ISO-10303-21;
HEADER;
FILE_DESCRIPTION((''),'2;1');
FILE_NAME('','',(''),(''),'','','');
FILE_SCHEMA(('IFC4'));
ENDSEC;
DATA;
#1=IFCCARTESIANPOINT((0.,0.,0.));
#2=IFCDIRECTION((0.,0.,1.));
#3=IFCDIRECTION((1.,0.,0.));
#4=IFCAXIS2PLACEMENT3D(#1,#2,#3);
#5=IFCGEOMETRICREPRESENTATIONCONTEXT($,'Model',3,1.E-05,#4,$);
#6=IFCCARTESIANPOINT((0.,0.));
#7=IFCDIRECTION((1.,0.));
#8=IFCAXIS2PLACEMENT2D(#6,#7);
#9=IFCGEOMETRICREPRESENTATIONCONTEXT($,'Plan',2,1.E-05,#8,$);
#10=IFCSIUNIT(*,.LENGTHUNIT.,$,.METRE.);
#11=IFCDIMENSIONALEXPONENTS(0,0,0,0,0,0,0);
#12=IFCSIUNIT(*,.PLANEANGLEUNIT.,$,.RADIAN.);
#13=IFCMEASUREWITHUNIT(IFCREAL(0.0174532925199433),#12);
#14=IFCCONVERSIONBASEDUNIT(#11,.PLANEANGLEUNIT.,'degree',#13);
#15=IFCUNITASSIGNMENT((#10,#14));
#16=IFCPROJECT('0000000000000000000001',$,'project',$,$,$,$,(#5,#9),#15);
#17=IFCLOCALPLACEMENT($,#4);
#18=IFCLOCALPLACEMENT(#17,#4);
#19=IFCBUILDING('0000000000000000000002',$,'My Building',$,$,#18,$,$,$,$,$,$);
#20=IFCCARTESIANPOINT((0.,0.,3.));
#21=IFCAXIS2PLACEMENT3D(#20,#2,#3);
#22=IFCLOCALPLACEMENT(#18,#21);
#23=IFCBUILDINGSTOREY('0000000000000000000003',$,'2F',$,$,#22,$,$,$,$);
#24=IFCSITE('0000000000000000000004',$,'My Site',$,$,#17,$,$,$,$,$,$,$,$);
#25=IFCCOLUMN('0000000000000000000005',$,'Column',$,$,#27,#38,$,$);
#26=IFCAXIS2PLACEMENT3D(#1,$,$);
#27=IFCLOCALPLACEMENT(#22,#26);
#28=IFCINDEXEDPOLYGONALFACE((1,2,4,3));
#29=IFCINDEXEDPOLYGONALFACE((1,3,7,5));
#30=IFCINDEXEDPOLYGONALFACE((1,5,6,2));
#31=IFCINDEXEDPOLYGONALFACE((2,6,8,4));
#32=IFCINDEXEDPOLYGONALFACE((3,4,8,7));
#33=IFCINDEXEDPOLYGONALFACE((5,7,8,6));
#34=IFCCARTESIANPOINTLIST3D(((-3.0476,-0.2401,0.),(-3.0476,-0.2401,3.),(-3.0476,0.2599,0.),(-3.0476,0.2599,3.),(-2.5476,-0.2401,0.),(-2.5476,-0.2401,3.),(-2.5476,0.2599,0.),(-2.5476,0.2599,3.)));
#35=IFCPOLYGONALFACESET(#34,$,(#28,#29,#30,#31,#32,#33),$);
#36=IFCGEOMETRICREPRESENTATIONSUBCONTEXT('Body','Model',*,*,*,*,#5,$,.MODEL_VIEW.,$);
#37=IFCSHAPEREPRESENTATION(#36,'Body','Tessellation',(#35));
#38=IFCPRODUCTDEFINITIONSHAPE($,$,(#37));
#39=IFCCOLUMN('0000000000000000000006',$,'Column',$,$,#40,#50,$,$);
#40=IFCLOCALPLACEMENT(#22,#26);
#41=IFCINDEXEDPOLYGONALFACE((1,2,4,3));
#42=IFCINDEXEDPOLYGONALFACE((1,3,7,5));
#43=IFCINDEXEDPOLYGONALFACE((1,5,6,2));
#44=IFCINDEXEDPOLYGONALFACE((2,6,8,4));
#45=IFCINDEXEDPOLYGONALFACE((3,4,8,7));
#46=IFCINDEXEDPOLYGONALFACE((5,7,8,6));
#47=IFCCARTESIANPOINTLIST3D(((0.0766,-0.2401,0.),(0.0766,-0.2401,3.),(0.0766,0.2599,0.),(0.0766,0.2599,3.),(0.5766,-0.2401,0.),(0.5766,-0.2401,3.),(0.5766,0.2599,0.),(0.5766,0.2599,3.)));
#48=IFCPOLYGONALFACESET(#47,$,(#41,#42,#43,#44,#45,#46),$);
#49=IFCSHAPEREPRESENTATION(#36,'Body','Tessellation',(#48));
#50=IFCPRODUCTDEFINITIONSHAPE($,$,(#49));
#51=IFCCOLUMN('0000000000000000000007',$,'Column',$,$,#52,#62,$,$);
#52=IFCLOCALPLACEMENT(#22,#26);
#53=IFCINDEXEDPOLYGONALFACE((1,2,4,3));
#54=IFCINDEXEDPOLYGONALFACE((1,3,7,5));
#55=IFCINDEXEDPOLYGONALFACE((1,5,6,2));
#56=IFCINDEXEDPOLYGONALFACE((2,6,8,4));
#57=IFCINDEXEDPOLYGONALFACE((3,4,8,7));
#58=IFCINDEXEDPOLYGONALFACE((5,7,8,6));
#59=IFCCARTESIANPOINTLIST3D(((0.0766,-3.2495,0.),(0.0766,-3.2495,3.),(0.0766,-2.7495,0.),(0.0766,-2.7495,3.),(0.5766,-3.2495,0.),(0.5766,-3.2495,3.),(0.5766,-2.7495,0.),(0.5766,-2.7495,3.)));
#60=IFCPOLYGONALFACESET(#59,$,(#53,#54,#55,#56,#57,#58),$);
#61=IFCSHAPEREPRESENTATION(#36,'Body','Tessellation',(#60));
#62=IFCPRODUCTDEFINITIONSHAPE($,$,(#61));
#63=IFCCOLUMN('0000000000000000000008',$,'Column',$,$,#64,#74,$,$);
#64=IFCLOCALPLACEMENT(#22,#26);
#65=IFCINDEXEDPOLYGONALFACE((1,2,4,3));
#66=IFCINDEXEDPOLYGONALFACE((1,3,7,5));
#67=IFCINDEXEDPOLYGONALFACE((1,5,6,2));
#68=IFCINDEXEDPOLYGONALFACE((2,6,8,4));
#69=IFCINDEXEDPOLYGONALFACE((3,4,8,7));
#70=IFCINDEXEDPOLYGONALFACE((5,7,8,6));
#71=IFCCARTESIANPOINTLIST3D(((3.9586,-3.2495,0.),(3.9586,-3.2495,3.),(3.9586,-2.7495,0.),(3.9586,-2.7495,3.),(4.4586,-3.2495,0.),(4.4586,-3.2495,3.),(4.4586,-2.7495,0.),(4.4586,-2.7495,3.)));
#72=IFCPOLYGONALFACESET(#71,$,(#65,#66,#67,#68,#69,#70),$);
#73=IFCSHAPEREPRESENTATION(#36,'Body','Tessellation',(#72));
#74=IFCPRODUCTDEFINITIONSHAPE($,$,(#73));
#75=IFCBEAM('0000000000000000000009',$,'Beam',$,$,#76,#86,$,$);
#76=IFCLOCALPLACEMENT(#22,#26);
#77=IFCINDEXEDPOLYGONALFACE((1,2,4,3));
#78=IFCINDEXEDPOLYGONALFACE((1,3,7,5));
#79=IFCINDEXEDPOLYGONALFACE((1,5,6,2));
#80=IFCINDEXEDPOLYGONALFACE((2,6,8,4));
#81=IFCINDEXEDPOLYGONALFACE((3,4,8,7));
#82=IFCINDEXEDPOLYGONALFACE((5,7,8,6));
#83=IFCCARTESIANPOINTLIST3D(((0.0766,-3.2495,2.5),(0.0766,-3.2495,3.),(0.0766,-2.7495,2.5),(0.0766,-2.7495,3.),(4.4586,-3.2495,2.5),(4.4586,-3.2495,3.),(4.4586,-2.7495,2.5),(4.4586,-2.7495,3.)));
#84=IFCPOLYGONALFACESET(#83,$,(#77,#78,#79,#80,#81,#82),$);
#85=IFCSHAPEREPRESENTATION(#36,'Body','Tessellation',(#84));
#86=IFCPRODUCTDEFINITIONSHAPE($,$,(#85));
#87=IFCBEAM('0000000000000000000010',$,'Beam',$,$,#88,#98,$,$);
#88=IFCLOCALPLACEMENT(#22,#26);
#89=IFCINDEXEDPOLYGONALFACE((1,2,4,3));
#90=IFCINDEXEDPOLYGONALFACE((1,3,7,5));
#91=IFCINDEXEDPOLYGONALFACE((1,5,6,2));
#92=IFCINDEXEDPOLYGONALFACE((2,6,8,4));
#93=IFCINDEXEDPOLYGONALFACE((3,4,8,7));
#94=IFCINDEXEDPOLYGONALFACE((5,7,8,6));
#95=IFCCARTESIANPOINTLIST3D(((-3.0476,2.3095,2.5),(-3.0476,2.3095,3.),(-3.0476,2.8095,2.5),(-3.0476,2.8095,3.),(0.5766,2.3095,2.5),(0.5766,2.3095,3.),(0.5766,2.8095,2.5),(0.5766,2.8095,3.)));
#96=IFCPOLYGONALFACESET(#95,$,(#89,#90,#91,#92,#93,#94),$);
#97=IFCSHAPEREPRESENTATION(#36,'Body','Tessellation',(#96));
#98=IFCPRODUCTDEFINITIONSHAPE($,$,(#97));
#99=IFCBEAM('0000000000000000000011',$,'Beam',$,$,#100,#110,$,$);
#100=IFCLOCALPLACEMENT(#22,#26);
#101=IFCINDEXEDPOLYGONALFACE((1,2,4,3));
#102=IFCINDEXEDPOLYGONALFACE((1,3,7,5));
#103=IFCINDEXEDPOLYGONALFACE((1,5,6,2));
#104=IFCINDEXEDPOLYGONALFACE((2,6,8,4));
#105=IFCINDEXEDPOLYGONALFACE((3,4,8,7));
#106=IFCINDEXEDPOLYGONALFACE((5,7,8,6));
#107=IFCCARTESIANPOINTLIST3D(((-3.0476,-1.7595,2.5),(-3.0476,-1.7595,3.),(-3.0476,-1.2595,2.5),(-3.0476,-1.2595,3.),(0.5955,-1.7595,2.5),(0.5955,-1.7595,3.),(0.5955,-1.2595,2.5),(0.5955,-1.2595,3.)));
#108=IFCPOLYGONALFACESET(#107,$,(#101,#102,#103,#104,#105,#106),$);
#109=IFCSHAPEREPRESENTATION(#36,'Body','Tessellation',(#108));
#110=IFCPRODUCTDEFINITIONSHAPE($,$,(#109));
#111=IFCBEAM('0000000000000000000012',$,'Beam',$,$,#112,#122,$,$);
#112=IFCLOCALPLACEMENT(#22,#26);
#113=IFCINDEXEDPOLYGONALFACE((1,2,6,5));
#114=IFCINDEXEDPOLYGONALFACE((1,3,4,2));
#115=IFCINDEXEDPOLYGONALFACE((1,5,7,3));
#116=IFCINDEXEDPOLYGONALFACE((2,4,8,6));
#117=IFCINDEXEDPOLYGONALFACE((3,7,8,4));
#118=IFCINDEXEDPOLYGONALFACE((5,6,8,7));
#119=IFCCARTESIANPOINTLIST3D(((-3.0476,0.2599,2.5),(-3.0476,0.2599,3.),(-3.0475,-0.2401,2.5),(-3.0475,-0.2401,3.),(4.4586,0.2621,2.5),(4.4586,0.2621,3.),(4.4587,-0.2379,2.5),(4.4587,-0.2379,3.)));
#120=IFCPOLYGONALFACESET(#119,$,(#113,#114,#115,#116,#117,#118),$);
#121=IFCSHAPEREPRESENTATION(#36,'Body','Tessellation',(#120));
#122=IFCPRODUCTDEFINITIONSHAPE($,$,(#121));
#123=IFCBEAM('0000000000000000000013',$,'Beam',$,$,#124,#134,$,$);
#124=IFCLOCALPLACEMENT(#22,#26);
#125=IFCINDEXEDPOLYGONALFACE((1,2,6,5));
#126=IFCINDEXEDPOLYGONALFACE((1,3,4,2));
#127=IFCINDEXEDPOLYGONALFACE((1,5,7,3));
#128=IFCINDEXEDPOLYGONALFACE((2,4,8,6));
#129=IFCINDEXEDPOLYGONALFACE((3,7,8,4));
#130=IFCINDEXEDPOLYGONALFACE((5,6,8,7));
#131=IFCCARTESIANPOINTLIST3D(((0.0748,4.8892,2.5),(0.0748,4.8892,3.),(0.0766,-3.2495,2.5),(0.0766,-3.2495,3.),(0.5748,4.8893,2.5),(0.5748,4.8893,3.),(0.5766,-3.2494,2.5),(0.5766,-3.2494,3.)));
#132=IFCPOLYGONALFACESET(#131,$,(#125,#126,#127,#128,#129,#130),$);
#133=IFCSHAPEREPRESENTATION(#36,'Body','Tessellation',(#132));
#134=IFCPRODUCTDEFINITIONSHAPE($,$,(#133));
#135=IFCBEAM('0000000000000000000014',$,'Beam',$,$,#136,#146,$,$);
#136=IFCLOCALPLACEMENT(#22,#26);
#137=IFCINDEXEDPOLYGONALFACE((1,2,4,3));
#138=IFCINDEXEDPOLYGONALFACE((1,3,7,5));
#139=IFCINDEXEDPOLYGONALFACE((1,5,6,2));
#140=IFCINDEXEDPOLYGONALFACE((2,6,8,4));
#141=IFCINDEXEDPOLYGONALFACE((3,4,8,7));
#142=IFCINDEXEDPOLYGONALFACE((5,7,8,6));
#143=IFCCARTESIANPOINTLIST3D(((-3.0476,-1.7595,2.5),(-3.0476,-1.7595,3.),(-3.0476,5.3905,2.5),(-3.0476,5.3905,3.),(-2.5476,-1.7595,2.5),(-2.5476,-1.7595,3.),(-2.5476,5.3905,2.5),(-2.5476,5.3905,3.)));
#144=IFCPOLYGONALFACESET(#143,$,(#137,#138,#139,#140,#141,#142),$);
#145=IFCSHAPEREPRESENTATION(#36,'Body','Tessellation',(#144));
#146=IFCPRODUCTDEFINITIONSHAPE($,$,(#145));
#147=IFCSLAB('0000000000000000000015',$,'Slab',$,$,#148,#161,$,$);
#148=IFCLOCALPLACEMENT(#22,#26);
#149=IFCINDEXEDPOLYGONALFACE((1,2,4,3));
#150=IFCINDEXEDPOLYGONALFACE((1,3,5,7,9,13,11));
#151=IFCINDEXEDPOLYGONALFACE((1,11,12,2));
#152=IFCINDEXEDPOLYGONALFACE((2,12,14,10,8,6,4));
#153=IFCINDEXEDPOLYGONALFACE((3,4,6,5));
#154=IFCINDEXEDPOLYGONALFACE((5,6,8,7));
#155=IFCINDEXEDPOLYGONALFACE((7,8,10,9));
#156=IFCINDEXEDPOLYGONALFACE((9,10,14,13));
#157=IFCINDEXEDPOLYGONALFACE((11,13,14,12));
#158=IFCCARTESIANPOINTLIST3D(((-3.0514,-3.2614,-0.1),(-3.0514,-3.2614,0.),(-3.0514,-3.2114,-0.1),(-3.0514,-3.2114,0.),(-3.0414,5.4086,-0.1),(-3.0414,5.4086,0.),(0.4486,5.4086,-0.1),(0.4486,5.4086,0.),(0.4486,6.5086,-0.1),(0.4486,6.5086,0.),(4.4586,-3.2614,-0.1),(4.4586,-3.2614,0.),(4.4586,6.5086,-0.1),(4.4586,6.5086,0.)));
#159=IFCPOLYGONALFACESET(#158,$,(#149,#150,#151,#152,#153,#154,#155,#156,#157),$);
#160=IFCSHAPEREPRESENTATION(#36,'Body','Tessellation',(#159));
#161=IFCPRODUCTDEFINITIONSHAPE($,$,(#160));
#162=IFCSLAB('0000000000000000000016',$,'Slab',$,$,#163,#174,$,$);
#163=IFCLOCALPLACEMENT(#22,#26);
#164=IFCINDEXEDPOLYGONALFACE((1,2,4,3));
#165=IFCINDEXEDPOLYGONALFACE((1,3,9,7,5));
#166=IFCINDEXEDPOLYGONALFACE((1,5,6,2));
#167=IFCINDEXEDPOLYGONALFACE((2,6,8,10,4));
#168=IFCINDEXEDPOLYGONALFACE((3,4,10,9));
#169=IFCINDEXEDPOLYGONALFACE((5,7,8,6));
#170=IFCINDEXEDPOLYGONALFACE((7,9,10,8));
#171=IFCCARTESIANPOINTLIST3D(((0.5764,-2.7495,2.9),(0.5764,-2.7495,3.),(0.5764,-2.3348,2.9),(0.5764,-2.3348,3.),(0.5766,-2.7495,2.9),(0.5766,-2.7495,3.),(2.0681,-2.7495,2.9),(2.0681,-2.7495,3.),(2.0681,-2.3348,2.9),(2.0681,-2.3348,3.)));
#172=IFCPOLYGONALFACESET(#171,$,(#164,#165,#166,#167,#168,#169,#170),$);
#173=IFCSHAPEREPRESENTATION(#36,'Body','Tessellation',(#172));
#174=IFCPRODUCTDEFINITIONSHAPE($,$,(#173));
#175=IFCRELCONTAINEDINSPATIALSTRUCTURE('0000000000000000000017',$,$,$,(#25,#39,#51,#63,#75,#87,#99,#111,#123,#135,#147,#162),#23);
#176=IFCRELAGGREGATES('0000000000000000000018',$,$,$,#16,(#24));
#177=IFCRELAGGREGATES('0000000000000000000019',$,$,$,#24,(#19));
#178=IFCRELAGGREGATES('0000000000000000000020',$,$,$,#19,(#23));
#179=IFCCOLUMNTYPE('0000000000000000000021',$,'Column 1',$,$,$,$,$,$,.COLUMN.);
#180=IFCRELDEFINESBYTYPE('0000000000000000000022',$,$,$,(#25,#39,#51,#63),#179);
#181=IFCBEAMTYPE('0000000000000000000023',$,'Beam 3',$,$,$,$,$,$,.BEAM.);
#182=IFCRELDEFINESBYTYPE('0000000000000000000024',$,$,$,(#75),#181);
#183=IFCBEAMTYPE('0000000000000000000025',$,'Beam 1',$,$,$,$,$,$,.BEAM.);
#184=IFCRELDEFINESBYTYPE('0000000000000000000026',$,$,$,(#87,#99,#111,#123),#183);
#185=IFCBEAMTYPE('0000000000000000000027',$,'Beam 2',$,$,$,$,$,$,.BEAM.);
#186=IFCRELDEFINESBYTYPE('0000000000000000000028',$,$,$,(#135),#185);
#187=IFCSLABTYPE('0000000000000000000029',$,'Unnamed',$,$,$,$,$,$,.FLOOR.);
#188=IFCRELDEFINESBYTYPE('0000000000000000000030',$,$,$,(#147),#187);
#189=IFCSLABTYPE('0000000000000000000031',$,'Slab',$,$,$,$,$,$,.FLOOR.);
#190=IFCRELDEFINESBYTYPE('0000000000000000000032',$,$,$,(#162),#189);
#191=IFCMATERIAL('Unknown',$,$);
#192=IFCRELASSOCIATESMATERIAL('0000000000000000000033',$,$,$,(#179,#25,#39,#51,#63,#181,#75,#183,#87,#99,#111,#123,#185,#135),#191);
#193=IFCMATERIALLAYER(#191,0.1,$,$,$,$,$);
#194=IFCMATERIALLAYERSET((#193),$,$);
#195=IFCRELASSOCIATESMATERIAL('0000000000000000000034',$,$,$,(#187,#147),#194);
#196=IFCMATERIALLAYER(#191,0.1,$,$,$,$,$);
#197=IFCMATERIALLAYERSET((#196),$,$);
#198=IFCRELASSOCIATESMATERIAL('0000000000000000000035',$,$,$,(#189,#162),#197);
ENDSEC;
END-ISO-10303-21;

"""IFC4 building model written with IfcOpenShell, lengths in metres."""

from ifc_helpers import new_model, entity, si_unit, converted_unit, frame, origin_with_axes, origin_2d_with_axis, place, context, subcontext, project, spatial, indexed_curve, outline, extrude, material, layer, layer_set, layer_usage, material_profile, profile_set, profile_usage, type_object, element, save


model = new_model("IFC4")

# Units and contexts
model_context = context("Model", 3, precision=1e-05, world=origin_with_axes())
plan_context = context("Plan", 2, precision=1e-05, world=origin_2d_with_axis())
body_context_1 = subcontext(model_context, "Body", "Model", "MODEL_VIEW")
ifc_project = project(units=[si_unit("LENGTHUNIT", "METRE"), converted_unit("PLANEANGLEUNIT", "degree", entity("IfcReal", 0.0174532925199433), si_unit("PLANEANGLEUNIT", "RADIAN"), dimensions=[0, 0, 0, 0, 0, 0, 0])], contexts=[model_context, plan_context])

# Site, building, storey
site_placement = place(None, origin_with_axes())
site = spatial("IfcSite", under=ifc_project, at=site_placement, Name="My Site")
building_placement = place(site_placement, origin_with_axes())
building = spatial("IfcBuilding", under=site, at=building_placement, Name="My Building")
storey_placement = place(building_placement, frame((0.0, 0.0, 3.0), z_axis=(0.0, 0.0, 1.0), x_axis=(1.0, 0.0, 0.0)))
storey = spatial("IfcBuildingStorey", under=building, at=storey_placement, Name="2F")

# Columns
ifc_material = material(Name="Unknown")
ifc_material_profile_1 = material_profile(ifc_material, outline(indexed_curve([(-0.25, -0.25), (0.25, -0.25), (0.25, 0.25), (-0.25, 0.25), (-0.25, -0.25)])))
ifc_profile_set_1 = profile_set([ifc_material_profile_1])
ifc_profile_usage_1 = profile_usage(ifc_profile_set_1, cardinal=7)
column_type = type_object("IfcColumnType", Name="Column 1", PredefinedType="COLUMN", material=ifc_profile_set_1)
column_1_placement = place(storey_placement, frame((-2.5476, 0.2599, 0.0), z_axis=(0.0, 0.0, 1.0), x_axis=(1.0, 0.0, 0.0)))
element("IfcColumn", 1, at=column_1_placement, inside=storey, type_object=column_type, material=ifc_profile_usage_1, Name="Column", context=body_context_1, shape_type="SweptSolid", body=[
    extrude(outline(indexed_curve([(-0.25, -0.25), (0.25, -0.25), (0.25, 0.25), (-0.25, 0.25), (-0.25, -0.25)])), frame((-0.25, -0.25, 0.0), z_axis=(0.0, 0.0, 1.0), x_axis=(1.0, 0.0, 0.0)), (0.0, 0.0, 1.0), 3.0),
])
ifc_profile_usage_2 = profile_usage(ifc_profile_set_1, cardinal=9)
column_2_placement = place(storey_placement, frame((0.0766, 0.2599, 0.0), z_axis=(0.0, 0.0, 1.0), x_axis=(1.0, 0.0, 0.0)))
element("IfcColumn", 2, at=column_2_placement, inside=storey, type_object=column_type, material=ifc_profile_usage_2, Name="Column", context=body_context_1, shape_type="SweptSolid", body=[
    extrude(outline(indexed_curve([(-0.25, -0.25), (0.25, -0.25), (0.25, 0.25), (-0.25, 0.25), (-0.25, -0.25)])), frame((0.25, -0.25, 0.0), z_axis=(0.0, 0.0, 1.0), x_axis=(1.0, 0.0, 0.0)), (0.0, 0.0, 1.0), 3.0),
])
ifc_profile_usage_3 = profile_usage(ifc_profile_set_1, cardinal=3)
column_3_placement = place(storey_placement, frame((0.0766, -3.2495, 0.0), z_axis=(0.0, 0.0, 1.0), x_axis=(1.0, 0.0, 0.0)))
element("IfcColumn", 3, at=column_3_placement, inside=storey, type_object=column_type, material=ifc_profile_usage_3, Name="Column", context=body_context_1, shape_type="SweptSolid", body=[
    extrude(outline(indexed_curve([(-0.25, -0.25), (0.25, -0.25), (0.25, 0.25), (-0.25, 0.25), (-0.25, -0.25)])), frame((0.25, 0.25, 0.0), z_axis=(0.0, 0.0, 1.0), x_axis=(1.0, 0.0, 0.0)), (0.0, 0.0, 1.0), 3.0),
])
ifc_profile_usage_4 = profile_usage(ifc_profile_set_1, cardinal=3)
column_4_placement = place(storey_placement, frame((3.9586, -3.2495, 0.0), z_axis=(0.0, 0.0, 1.0), x_axis=(1.0, 0.0, 0.0)))
element("IfcColumn", 4, at=column_4_placement, inside=storey, type_object=column_type, material=ifc_profile_usage_4, Name="Column", context=body_context_1, shape_type="SweptSolid", body=[
    extrude(outline(indexed_curve([(-0.25, -0.25), (0.25, -0.25), (0.25, 0.25), (-0.25, 0.25), (-0.25, -0.25)])), frame((0.25, 0.25, 0.0), z_axis=(0.0, 0.0, 1.0), x_axis=(1.0, 0.0, 0.0)), (0.0, 0.0, 1.0), 3.0),
])

# Beams
ifc_material_profile_2 = material_profile(ifc_material, outline(indexed_curve([(-0.25, -0.25), (0.25, -0.25), (0.25, 0.25), (-0.25, 0.25), (-0.25, -0.25)])))
ifc_profile_set_2 = profile_set([ifc_material_profile_2])
ifc_profile_usage_5 = profile_usage(ifc_profile_set_2, cardinal=7)
beam_type_1 = type_object("IfcBeamType", Name="Beam 3", PredefinedType="BEAM", material=ifc_profile_set_2)
beam_1_placement = place(storey_placement, frame((0.0766, -2.7495, 3.0), z_axis=(1.0, 0.0, 0.0), x_axis=(0.0, 1.0, 0.0)))
element("IfcBeam", 5, at=beam_1_placement, inside=storey, type_object=beam_type_1, material=ifc_profile_usage_5, Name="Beam", context=body_context_1, shape_type="SweptSolid", body=[
    extrude(outline(indexed_curve([(-0.25, -0.25), (0.25, -0.25), (0.25, 0.25), (-0.25, 0.25), (-0.25, -0.25)])), frame((-0.25, -0.25, 0.0), z_axis=(0.0, 0.0, 1.0), x_axis=(1.0, 0.0, 0.0)), (0.0, 0.0, 1.0), 4.382),
])
ifc_material_profile_3 = material_profile(ifc_material, outline(indexed_curve([(-0.25, -0.25), (0.25, -0.25), (0.25, 0.25), (-0.25, 0.25), (-0.25, -0.25)])))
ifc_profile_set_3 = profile_set([ifc_material_profile_3])
ifc_profile_usage_6 = profile_usage(ifc_profile_set_3, cardinal=7)
beam_type_2 = type_object("IfcBeamType", Name="Beam 1", PredefinedType="BEAM", material=ifc_profile_set_3)
beam_2_placement = place(storey_placement, frame((0.5766, 2.3095, 3.0), z_axis=(-1.0, -0.000001, 0.000001), x_axis=(0.000001, -1.0, 0.0)))
element("IfcBeam", 6, at=beam_2_placement, inside=storey, type_object=beam_type_2, material=ifc_profile_usage_6, Name="Beam", context=body_context_1, shape_type="SweptSolid", body=[
    extrude(outline(indexed_curve([(-0.25, -0.25), (0.25, -0.25), (0.25, 0.25), (-0.25, 0.25), (-0.25, -0.25)])), frame((-0.25, -0.25, 0.0), z_axis=(0.0, 0.0, 1.0), x_axis=(1.0, 0.0, 0.0)), (0.0, 0.0, 1.0), 3.6242),
])
ifc_profile_usage_7 = profile_usage(ifc_profile_set_3, cardinal=1)
beam_3_placement = place(storey_placement, frame((-3.0476, -1.2595, 2.5), z_axis=(1.0, 0.0, 0.0), x_axis=(0.0, 1.0, 0.0)))
element("IfcBeam", 7, at=beam_3_placement, inside=storey, type_object=beam_type_2, material=ifc_profile_usage_7, Name="Beam", context=body_context_1, shape_type="SweptSolid", body=[
    extrude(outline(indexed_curve([(-0.25, -0.25), (0.25, -0.25), (0.25, 0.25), (-0.25, 0.25), (-0.25, -0.25)])), frame((-0.25, 0.25, 0.0), z_axis=(0.0, 0.0, 1.0), x_axis=(1.0, 0.0, 0.0)), (0.0, 0.0, 1.0), 3.6431),
])
ifc_profile_usage_8 = profile_usage(ifc_profile_set_3, cardinal=7)
beam_4_placement = place(storey_placement, frame((-3.0476, 0.2599, 3.0), z_axis=(1.0, 0.000292, 0.0), x_axis=(-0.000292, 1.0, 0.0)))
element("IfcBeam", 8, at=beam_4_placement, inside=storey, type_object=beam_type_2, material=ifc_profile_usage_8, Name="Beam", context=body_context_1, shape_type="SweptSolid", body=[
    extrude(outline(indexed_curve([(-0.25, -0.25), (0.25, -0.25), (0.25, 0.25), (-0.25, 0.25), (-0.25, -0.25)])), frame((-0.25, -0.25, 0.0), z_axis=(0.0, 0.0, 1.0), x_axis=(1.0, 0.0, 0.0)), (0.0, 0.0, 1.0), 7.5062),
])
ifc_profile_usage_9 = profile_usage(ifc_profile_set_3, cardinal=7)
beam_5_placement = place(storey_placement, frame((0.0766, -3.2495, 3.0), z_axis=(-0.000222, 1.0, 0.0), x_axis=(-1.0, -0.000222, 0.0)))
element("IfcBeam", 9, at=beam_5_placement, inside=storey, type_object=beam_type_2, material=ifc_profile_usage_9, Name="Beam", context=body_context_1, shape_type="SweptSolid", body=[
    extrude(outline(indexed_curve([(-0.25, -0.25), (0.25, -0.25), (0.25, 0.25), (-0.25, 0.25), (-0.25, -0.25)])), frame((-0.25, -0.25, 0.0), z_axis=(0.0, 0.0, 1.0), x_axis=(1.0, 0.0, 0.0)), (0.0, 0.0, 1.0), 8.1387),
])
ifc_material_profile_4 = material_profile(ifc_material, outline(indexed_curve([(-0.25, -0.25), (0.25, -0.25), (0.25, 0.25), (-0.25, 0.25), (-0.25, -0.25)])))
ifc_profile_set_4 = profile_set([ifc_material_profile_4])
ifc_profile_usage_10 = profile_usage(ifc_profile_set_4, cardinal=7)
beam_type_3 = type_object("IfcBeamType", Name="Beam 2", PredefinedType="BEAM", material=ifc_profile_set_4)
beam_6_placement = place(storey_placement, frame((-3.0476, -1.7595, 3.0), z_axis=(0.0, 1.0, 0.0), x_axis=(-1.0, 0.0, 0.0)))
element("IfcBeam", 10, at=beam_6_placement, inside=storey, type_object=beam_type_3, material=ifc_profile_usage_10, Name="Beam", context=body_context_1, shape_type="SweptSolid", body=[
    extrude(outline(indexed_curve([(-0.25, -0.25), (0.25, -0.25), (0.25, 0.25), (-0.25, 0.25), (-0.25, -0.25)])), frame((-0.25, -0.25, 0.0), z_axis=(0.0, 0.0, 1.0), x_axis=(1.0, 0.0, 0.0)), (0.0, 0.0, 1.0), 7.15),
])

# Slabs
ifc_layer_1 = layer(ifc_material, 0.1)
ifc_layer_set_1 = layer_set([ifc_layer_1])
ifc_layer_usage_1 = layer_usage(ifc_layer_set_1, "AXIS3", "POSITIVE", -0.1)
slab_type_1 = type_object("IfcSlabType", Name="Unnamed", PredefinedType="FLOOR", material=ifc_layer_set_1)
slab_1_placement = place(storey_placement, frame((-3.0514, -3.2114, 0.0), z_axis=(0.0, 0.0, 1.0), x_axis=(1.0, 0.0, 0.0)))
element("IfcSlab", 11, at=slab_1_placement, inside=storey, type_object=slab_type_1, material=ifc_layer_usage_1, Name="Slab", context=body_context_1, shape_type="SweptSolid", body=[
    extrude(outline(indexed_curve([(0.0, 0.0), (0.0, -0.05), (7.51, -0.05), (7.51, 9.72), (3.5, 9.72), (3.5, 8.62), (0.01, 8.62), (0.0, 0.0)])), frame((0.0, 0.0, -0.1), z_axis=(0.0, 0.0, 1.0), x_axis=(1.0, 0.0, 0.0)), (0.0, 0.0, 1.0), 0.1),
])
ifc_layer_2 = layer(ifc_material, 0.1)
ifc_layer_set_2 = layer_set([ifc_layer_2])
ifc_layer_usage_2 = layer_usage(ifc_layer_set_2, "AXIS3", "POSITIVE", -0.1)
slab_type_2 = type_object("IfcSlabType", Name="Slab", PredefinedType="FLOOR", material=ifc_layer_set_2)
slab_2_placement = place(storey_placement, frame((0.5766, -2.7495, 3.0), z_axis=(0.0, 0.0, 1.0), x_axis=(1.0, 0.0, 0.0)))
element("IfcSlab", 12, at=slab_2_placement, inside=storey, type_object=slab_type_2, material=ifc_layer_usage_2, Name="Slab", context=body_context_1, shape_type="SweptSolid", body=[
    extrude(outline(indexed_curve([(-0.0002, 0.0), (-0.0002, 0.4148), (1.4914, 0.4148), (1.4914, 0.0), (0.0, 0.0), (-0.0002, 0.0)])), frame((0.0, 0.0, -0.1), z_axis=(0.0, 0.0, 1.0), x_axis=(1.0, 0.0, 0.0)), (0.0, 0.0, 1.0), 0.1),
])

save(model, "model.ifc")
